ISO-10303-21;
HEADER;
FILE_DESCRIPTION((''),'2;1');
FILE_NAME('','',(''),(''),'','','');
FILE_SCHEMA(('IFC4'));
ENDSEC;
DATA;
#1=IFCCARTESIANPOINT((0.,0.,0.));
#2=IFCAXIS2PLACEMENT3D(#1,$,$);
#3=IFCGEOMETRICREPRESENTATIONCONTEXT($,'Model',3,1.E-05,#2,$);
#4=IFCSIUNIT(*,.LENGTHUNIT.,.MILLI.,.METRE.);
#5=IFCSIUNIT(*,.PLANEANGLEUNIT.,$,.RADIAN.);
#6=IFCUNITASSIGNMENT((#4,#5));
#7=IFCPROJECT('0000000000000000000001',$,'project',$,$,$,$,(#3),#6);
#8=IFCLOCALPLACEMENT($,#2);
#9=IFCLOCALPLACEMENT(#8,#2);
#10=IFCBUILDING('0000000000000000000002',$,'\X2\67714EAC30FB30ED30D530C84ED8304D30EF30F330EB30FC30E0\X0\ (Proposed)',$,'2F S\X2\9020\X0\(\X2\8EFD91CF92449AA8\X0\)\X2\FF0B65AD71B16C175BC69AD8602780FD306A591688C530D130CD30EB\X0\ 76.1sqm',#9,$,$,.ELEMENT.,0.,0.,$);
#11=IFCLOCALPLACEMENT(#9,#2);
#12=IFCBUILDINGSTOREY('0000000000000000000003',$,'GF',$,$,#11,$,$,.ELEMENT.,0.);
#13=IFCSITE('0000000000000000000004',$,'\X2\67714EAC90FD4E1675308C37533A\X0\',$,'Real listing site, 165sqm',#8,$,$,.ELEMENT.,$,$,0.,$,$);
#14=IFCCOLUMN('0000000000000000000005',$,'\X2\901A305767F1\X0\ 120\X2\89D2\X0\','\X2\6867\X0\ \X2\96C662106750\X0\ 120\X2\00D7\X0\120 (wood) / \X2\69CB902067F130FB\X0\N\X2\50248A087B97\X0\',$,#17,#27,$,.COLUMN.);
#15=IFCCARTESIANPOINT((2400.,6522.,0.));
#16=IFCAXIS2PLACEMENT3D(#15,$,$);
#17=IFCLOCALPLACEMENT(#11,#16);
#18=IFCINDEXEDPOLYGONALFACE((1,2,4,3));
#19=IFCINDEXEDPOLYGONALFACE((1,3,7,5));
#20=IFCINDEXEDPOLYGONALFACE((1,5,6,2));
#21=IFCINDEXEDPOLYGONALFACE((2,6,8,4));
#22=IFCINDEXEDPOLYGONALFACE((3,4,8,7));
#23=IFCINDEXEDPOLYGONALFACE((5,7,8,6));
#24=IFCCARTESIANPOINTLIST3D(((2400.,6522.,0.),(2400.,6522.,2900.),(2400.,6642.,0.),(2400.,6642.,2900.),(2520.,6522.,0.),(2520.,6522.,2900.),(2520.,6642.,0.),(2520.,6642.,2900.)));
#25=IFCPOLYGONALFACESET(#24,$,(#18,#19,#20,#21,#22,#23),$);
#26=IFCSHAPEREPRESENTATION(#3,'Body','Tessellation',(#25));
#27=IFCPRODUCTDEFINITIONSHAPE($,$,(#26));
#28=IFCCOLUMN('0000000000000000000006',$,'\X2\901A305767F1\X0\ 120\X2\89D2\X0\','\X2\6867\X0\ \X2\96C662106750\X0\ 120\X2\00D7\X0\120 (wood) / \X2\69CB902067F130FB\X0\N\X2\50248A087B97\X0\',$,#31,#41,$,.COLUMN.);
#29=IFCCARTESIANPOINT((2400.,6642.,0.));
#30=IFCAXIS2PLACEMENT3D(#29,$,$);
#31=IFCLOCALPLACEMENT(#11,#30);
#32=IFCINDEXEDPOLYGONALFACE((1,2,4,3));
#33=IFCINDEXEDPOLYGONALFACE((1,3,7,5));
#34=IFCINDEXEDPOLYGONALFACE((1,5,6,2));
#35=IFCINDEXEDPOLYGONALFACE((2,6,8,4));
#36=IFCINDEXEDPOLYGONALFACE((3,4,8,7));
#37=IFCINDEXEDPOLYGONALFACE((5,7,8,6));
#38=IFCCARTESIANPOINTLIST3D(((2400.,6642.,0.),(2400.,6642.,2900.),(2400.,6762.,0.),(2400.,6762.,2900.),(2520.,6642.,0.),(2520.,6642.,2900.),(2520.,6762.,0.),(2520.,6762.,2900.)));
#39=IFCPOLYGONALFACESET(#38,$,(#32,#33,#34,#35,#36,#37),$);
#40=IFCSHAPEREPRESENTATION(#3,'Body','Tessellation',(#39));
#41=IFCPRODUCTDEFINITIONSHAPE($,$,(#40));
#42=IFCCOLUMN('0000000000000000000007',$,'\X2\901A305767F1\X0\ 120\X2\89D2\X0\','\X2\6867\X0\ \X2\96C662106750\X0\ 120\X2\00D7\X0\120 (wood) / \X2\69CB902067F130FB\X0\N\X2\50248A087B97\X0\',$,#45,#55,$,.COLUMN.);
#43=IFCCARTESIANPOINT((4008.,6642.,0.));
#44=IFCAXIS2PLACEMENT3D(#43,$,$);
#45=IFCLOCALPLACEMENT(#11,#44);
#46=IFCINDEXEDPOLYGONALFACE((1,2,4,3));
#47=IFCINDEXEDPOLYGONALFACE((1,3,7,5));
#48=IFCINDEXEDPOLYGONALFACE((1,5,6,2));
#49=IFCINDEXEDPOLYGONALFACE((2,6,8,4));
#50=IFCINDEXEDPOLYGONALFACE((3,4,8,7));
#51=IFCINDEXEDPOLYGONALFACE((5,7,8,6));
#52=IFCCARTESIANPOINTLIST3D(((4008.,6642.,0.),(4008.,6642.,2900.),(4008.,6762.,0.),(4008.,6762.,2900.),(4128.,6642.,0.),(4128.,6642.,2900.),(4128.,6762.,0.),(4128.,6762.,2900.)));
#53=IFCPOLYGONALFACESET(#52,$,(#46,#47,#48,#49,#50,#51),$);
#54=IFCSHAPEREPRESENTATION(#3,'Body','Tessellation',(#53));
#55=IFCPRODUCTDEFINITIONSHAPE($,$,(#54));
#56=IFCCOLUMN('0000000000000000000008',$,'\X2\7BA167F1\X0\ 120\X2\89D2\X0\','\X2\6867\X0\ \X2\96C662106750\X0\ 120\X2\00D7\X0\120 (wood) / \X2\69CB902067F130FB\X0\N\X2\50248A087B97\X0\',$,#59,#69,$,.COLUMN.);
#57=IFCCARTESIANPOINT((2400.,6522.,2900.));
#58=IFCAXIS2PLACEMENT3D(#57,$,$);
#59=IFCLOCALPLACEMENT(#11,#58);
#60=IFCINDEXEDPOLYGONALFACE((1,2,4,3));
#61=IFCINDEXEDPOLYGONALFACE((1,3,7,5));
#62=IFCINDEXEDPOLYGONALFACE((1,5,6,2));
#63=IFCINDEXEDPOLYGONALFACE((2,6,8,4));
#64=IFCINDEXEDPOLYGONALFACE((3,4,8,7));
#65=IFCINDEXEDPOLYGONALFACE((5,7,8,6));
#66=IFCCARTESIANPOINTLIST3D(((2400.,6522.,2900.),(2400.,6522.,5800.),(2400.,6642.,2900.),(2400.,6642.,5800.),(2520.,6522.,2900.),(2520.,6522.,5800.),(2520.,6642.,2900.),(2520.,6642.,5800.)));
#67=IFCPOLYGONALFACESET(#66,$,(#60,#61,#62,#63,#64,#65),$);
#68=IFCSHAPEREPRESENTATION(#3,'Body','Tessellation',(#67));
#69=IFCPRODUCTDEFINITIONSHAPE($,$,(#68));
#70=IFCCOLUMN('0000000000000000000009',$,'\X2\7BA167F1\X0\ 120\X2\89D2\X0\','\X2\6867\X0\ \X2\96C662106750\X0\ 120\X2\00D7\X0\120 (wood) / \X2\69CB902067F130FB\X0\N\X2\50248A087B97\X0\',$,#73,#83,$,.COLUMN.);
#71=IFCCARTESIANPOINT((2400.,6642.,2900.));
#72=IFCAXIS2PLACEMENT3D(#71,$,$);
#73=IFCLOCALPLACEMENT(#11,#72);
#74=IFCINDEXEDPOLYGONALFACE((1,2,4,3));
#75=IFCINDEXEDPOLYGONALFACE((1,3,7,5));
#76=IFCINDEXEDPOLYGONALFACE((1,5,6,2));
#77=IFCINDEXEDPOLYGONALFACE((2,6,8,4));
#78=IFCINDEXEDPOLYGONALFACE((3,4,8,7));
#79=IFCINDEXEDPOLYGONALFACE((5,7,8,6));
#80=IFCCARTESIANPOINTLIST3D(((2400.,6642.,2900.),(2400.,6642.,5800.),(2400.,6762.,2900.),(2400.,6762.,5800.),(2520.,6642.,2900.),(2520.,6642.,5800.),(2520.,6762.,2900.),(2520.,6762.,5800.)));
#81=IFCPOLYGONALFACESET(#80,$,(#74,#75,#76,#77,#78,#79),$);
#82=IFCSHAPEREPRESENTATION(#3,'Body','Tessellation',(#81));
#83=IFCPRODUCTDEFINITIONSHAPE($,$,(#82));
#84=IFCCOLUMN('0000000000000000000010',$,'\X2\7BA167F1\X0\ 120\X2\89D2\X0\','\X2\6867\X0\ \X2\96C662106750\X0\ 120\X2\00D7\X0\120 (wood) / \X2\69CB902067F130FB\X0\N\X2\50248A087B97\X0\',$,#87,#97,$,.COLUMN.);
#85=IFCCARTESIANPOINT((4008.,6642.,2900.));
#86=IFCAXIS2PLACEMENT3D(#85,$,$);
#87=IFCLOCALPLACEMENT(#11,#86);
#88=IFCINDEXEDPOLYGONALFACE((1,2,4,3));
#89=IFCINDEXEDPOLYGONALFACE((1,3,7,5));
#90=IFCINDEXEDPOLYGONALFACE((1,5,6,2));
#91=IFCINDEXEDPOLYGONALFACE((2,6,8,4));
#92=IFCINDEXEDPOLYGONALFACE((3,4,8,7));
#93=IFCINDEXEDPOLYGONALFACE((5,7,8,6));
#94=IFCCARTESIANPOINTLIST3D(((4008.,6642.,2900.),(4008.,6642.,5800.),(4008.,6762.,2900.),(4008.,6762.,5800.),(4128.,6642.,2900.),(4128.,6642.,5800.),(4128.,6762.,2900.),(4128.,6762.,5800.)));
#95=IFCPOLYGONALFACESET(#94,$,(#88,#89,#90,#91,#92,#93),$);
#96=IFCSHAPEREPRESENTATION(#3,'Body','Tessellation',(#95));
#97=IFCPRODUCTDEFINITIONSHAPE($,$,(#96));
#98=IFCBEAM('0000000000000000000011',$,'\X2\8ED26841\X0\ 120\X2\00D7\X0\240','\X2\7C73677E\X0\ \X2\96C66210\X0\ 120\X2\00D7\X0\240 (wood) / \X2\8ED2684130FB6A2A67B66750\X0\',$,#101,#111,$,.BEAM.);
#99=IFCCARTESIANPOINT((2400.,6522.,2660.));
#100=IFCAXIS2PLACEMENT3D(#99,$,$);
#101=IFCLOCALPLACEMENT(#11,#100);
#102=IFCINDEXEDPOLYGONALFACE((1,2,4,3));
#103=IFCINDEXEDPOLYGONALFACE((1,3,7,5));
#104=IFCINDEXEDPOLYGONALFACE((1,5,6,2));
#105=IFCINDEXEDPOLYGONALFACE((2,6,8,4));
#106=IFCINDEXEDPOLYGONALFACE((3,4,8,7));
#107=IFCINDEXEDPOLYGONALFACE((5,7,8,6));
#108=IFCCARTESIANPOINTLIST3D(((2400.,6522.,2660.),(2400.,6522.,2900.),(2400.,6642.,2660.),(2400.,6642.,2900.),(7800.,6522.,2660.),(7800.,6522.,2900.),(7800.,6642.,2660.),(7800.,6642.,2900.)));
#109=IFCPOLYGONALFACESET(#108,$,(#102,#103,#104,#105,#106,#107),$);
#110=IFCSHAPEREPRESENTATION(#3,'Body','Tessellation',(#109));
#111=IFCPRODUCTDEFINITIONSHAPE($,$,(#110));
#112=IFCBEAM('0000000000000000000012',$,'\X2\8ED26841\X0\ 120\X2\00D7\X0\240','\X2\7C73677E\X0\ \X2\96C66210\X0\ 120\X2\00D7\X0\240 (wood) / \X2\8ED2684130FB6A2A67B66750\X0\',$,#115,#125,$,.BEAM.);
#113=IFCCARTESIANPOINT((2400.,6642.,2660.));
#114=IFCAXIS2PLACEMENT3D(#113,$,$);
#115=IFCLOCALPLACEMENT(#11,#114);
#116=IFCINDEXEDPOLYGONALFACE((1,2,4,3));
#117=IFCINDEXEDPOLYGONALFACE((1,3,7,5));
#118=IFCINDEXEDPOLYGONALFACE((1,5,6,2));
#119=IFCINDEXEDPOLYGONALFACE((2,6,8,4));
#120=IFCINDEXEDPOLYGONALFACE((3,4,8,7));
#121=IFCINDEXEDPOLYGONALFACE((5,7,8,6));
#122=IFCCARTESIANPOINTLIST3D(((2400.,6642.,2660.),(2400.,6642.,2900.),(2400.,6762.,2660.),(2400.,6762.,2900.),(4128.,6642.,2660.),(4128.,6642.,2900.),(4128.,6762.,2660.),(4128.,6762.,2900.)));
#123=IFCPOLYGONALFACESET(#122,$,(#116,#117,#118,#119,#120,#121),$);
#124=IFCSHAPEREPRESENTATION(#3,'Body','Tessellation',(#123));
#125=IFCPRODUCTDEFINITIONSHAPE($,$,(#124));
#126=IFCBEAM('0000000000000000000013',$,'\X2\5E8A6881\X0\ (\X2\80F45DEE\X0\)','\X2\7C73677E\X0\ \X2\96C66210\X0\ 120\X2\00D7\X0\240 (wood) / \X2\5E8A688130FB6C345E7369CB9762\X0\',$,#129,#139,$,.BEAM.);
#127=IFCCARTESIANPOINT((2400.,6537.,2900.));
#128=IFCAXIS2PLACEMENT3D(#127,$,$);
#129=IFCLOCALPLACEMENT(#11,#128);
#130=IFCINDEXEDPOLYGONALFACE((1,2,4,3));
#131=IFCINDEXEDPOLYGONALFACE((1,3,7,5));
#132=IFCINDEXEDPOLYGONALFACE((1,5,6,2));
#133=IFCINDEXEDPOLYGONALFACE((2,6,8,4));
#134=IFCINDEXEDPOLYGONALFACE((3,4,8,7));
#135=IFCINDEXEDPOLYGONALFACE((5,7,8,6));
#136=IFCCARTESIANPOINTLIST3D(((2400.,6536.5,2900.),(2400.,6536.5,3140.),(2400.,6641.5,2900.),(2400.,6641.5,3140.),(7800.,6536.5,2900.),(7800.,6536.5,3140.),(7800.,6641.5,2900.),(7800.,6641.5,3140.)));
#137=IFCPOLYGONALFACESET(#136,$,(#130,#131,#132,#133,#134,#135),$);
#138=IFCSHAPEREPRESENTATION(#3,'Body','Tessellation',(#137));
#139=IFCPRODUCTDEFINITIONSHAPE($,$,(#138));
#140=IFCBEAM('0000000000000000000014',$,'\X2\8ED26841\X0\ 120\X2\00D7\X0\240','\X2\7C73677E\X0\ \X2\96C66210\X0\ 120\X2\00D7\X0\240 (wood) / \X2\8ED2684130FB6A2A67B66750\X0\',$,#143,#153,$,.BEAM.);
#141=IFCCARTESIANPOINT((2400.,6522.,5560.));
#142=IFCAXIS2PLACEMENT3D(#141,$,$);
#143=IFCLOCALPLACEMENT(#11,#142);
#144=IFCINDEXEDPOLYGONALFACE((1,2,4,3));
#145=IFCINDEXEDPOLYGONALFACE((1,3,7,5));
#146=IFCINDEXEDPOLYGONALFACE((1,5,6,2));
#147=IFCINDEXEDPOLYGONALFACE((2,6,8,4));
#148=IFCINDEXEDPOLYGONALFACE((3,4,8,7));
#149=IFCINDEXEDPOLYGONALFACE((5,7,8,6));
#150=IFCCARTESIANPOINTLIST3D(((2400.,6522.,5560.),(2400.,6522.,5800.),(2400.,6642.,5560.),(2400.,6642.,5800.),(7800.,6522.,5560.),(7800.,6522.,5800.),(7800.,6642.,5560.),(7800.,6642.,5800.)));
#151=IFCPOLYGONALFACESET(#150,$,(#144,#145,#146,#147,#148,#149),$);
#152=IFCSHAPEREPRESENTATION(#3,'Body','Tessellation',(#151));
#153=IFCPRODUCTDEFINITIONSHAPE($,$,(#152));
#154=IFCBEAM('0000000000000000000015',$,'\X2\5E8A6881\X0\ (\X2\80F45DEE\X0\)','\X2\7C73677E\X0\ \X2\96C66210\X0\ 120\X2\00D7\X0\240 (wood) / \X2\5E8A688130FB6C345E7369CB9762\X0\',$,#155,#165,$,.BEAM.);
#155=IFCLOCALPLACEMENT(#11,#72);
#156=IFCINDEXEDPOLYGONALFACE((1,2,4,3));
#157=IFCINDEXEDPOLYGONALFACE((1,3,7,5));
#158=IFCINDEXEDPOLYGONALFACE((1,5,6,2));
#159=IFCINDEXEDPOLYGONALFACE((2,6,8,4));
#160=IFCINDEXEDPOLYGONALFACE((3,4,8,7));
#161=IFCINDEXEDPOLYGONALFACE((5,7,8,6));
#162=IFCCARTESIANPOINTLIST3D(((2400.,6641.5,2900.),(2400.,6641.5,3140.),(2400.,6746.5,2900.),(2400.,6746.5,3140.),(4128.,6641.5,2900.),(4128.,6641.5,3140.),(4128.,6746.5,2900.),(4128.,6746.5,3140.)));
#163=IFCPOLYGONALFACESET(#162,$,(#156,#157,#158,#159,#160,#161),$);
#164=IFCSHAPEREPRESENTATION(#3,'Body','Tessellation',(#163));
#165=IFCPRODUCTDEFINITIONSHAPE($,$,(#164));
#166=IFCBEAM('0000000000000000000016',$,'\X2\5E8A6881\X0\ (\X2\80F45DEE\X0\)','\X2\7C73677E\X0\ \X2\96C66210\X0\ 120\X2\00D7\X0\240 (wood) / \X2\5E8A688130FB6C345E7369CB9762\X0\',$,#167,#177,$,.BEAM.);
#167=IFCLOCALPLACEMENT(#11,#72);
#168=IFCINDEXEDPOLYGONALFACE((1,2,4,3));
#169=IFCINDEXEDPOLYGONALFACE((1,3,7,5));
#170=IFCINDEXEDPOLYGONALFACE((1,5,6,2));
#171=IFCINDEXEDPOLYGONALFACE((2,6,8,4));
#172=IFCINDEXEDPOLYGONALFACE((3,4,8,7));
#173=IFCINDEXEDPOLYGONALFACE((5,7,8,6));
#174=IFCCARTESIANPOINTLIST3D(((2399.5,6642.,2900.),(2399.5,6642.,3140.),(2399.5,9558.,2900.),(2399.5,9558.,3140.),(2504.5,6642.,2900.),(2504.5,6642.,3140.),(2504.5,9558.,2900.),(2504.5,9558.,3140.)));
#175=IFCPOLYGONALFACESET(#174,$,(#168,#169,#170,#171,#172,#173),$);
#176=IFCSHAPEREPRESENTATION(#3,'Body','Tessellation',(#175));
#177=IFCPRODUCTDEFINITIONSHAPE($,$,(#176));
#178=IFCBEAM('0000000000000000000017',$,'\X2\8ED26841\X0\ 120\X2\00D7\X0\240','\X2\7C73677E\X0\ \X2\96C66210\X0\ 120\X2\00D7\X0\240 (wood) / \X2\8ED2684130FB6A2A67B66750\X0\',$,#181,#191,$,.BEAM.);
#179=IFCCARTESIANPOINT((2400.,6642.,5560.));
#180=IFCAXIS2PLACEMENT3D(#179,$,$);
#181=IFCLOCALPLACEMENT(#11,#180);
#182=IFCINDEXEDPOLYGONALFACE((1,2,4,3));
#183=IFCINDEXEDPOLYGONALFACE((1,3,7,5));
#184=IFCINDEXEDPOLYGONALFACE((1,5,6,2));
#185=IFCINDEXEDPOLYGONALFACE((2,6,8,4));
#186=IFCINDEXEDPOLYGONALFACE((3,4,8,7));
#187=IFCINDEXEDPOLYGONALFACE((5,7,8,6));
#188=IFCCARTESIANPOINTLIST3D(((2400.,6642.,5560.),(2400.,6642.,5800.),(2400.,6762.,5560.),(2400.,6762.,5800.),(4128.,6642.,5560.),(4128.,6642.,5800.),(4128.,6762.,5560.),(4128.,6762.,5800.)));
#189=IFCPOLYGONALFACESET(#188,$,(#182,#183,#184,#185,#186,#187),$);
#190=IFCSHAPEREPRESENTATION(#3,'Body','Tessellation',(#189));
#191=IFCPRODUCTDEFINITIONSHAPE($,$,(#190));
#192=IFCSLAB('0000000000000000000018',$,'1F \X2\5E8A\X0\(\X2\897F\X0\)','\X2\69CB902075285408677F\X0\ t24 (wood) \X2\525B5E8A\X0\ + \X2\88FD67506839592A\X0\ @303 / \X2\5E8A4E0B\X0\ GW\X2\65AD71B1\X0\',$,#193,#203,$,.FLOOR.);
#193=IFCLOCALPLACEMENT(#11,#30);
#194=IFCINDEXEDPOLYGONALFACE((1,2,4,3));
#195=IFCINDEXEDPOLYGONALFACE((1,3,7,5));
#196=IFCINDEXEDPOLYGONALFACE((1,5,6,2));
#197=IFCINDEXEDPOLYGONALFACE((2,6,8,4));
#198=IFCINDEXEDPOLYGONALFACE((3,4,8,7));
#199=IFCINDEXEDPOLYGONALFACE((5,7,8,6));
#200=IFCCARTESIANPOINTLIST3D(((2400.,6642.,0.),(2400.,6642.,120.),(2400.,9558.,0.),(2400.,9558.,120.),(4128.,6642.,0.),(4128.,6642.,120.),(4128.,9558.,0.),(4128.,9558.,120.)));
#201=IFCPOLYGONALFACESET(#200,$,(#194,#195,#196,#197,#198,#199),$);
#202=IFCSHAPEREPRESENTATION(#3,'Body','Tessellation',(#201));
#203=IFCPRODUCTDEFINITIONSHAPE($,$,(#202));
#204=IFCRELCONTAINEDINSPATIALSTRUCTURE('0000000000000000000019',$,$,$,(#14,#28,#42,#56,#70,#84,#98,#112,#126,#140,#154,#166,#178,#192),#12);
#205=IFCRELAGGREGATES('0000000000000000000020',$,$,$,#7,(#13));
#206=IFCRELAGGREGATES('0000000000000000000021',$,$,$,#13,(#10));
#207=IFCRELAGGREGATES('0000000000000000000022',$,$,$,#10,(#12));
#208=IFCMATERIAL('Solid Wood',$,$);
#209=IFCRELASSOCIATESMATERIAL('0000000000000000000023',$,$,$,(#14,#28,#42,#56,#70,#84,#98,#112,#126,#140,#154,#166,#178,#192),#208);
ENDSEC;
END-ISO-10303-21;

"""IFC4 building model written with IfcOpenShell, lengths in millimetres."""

from ifc_helpers import new_model, si_unit, frame, frame_2d, origin, place, context, project, spatial, rectangle, extrude, material, element, save


model = new_model("IFC4")

# Units and contexts
model_context = context("Model", 3, precision=1e-05, world=origin())
ifc_project = project(units=[si_unit("LENGTHUNIT", "METRE", prefix="MILLI"), si_unit("PLANEANGLEUNIT", "RADIAN")], contexts=[model_context])

# Site, building, storey
site_placement = place(None, origin())
site = spatial("IfcSite", under=ifc_project, at=site_placement, Name="東京都世田谷区", ObjectType="Real listing site, 165sqm", CompositionType="ELEMENT", RefElevation=0.0)
building_placement = place(site_placement, origin())
building = spatial("IfcBuilding", under=site, at=building_placement, Name="東京・ロフト付きワンルーム (Proposed)", ObjectType="2F S造(軽量鉄骨)＋断熱気密高性能な外装パネル 76.1sqm", CompositionType="ELEMENT", ElevationOfRefHeight=0.0, ElevationOfTerrain=0.0)
storey_placement = place(building_placement, origin())
storey = spatial("IfcBuildingStorey", under=building, at=storey_placement, Name="GF", CompositionType="ELEMENT", Elevation=0.0)

# Columns
ifc_material_1 = material(Name="Solid Wood")
column_1_placement = place(storey_placement, frame((2400.0, 6522.0, 0.0)))
element("IfcColumn", 1, at=column_1_placement, inside=storey, material=ifc_material_1, Name="通し柱 120角", Description="桧 集成材 120×120 (wood) / 構造柱・N値計算", PredefinedType="COLUMN", context=model_context, shape_type="SweptSolid", body=[
    extrude(rectangle(XDim=120.0, YDim=120.0, at=frame_2d((60.0, 60.0))), frame((2400.0, 6522.0, 0.0)), (0.0, 0.0, 1.0), 2900.0),
])
column_2_placement = place(storey_placement, frame((2400.0, 6642.0, 0.0)))
element("IfcColumn", 2, at=column_2_placement, inside=storey, material=ifc_material_1, Name="通し柱 120角", Description="桧 集成材 120×120 (wood) / 構造柱・N値計算", PredefinedType="COLUMN", context=model_context, shape_type="SweptSolid", body=[
    extrude(rectangle(XDim=120.0, YDim=120.0, at=frame_2d((60.0, 60.0))), frame((2400.0, 6642.0, 0.0)), (0.0, 0.0, 1.0), 2900.0),
])
column_3_placement = place(storey_placement, frame((4008.0, 6642.0, 0.0)))
element("IfcColumn", 3, at=column_3_placement, inside=storey, material=ifc_material_1, Name="通し柱 120角", Description="桧 集成材 120×120 (wood) / 構造柱・N値計算", PredefinedType="COLUMN", context=model_context, shape_type="SweptSolid", body=[
    extrude(rectangle(XDim=120.0, YDim=120.0, at=frame_2d((60.0, 60.0))), frame((4008.0, 6642.0, 0.0)), (0.0, 0.0, 1.0), 2900.0),
])
column_4_placement = place(storey_placement, frame((2400.0, 6522.0, 2900.0)))
element("IfcColumn", 4, at=column_4_placement, inside=storey, material=ifc_material_1, Name="管柱 120角", Description="桧 集成材 120×120 (wood) / 構造柱・N値計算", PredefinedType="COLUMN", context=model_context, shape_type="SweptSolid", body=[
    extrude(rectangle(XDim=120.0, YDim=120.0, at=frame_2d((60.0, 60.0))), frame((2400.0, 6522.0, 2900.0)), (0.0, 0.0, 1.0), 2900.0),
])
column_5_placement = place(storey_placement, frame((2400.0, 6642.0, 2900.0)))
element("IfcColumn", 5, at=column_5_placement, inside=storey, material=ifc_material_1, Name="管柱 120角", Description="桧 集成材 120×120 (wood) / 構造柱・N値計算", PredefinedType="COLUMN", context=model_context, shape_type="SweptSolid", body=[
    extrude(rectangle(XDim=120.0, YDim=120.0, at=frame_2d((60.0, 60.0))), frame((2400.0, 6642.0, 2900.0)), (0.0, 0.0, 1.0), 2900.0),
])
column_6_placement = place(storey_placement, frame((4008.0, 6642.0, 2900.0)))
element("IfcColumn", 6, at=column_6_placement, inside=storey, material=ifc_material_1, Name="管柱 120角", Description="桧 集成材 120×120 (wood) / 構造柱・N値計算", PredefinedType="COLUMN", context=model_context, shape_type="SweptSolid", body=[
    extrude(rectangle(XDim=120.0, YDim=120.0, at=frame_2d((60.0, 60.0))), frame((4008.0, 6642.0, 2900.0)), (0.0, 0.0, 1.0), 2900.0),
])

# Beams
beam_1_placement = place(storey_placement, frame((2400.0, 6522.0, 2660.0)))
element("IfcBeam", 7, at=beam_1_placement, inside=storey, material=ifc_material_1, Name="軒桁 120×240", Description="米松 集成 120×240 (wood) / 軒桁・横架材", PredefinedType="BEAM", context=model_context, shape_type="SweptSolid", body=[
    extrude(rectangle(XDim=5400.0, YDim=120.0, at=frame_2d((2700.0, 60.0))), frame((2400.0, 6522.0, 2660.0)), (0.0, 0.0, 1.0), 240.0),
])
beam_2_placement = place(storey_placement, frame((2400.0, 6642.0, 2660.0)))
element("IfcBeam", 8, at=beam_2_placement, inside=storey, material=ifc_material_1, Name="軒桁 120×240", Description="米松 集成 120×240 (wood) / 軒桁・横架材", PredefinedType="BEAM", context=model_context, shape_type="SweptSolid", body=[
    extrude(rectangle(XDim=1728.0, YDim=120.0, at=frame_2d((864.0, 60.0))), frame((2400.0, 6642.0, 2660.0)), (0.0, 0.0, 1.0), 240.0),
])
beam_3_placement = place(storey_placement, frame((2400.0, 6537.0, 2900.0)))
element("IfcBeam", 9, at=beam_3_placement, inside=storey, material=ifc_material_1, Name="床梁 (胴差)", Description="米松 集成 120×240 (wood) / 床梁・水平構面", PredefinedType="BEAM", context=model_context, shape_type="SweptSolid", body=[
    extrude(rectangle(XDim=5400.0, YDim=105.0, at=frame_2d((2700.0, 52.0))), frame((2400.0, 6537.0, 2900.0)), (0.0, 0.0, 1.0), 240.0),
])
beam_4_placement = place(storey_placement, frame((2400.0, 6522.0, 5560.0)))
element("IfcBeam", 10, at=beam_4_placement, inside=storey, material=ifc_material_1, Name="軒桁 120×240", Description="米松 集成 120×240 (wood) / 軒桁・横架材", PredefinedType="BEAM", context=model_context, shape_type="SweptSolid", body=[
    extrude(rectangle(XDim=5400.0, YDim=120.0, at=frame_2d((2700.0, 60.0))), frame((2400.0, 6522.0, 5560.0)), (0.0, 0.0, 1.0), 240.0),
])
beam_5_placement = place(storey_placement, frame((2400.0, 6642.0, 2900.0)))
element("IfcBeam", 11, at=beam_5_placement, inside=storey, material=ifc_material_1, Name="床梁 (胴差)", Description="米松 集成 120×240 (wood) / 床梁・水平構面", PredefinedType="BEAM", context=model_context, shape_type="SweptSolid", body=[
    extrude(rectangle(XDim=1728.0, YDim=105.0, at=frame_2d((864.0, 52.0))), frame((2400.0, 6642.0, 2900.0)), (0.0, 0.0, 1.0), 240.0),
])
beam_6_placement = place(storey_placement, frame((2400.0, 6642.0, 2900.0)))
element("IfcBeam", 12, at=beam_6_placement, inside=storey, material=ifc_material_1, Name="床梁 (胴差)", Description="米松 集成 120×240 (wood) / 床梁・水平構面", PredefinedType="BEAM", context=model_context, shape_type="SweptSolid", body=[
    extrude(rectangle(XDim=105.0, YDim=2916.0, at=frame_2d((52.0, 1458.0))), frame((2400.0, 6642.0, 2900.0)), (0.0, 0.0, 1.0), 240.0),
])
beam_7_placement = place(storey_placement, frame((2400.0, 6642.0, 5560.0)))
element("IfcBeam", 13, at=beam_7_placement, inside=storey, material=ifc_material_1, Name="軒桁 120×240", Description="米松 集成 120×240 (wood) / 軒桁・横架材", PredefinedType="BEAM", context=model_context, shape_type="SweptSolid", body=[
    extrude(rectangle(XDim=1728.0, YDim=120.0, at=frame_2d((864.0, 60.0))), frame((2400.0, 6642.0, 5560.0)), (0.0, 0.0, 1.0), 240.0),
])

# Slab
slab_1_placement = place(storey_placement, frame((2400.0, 6642.0, 0.0)))
element("IfcSlab", 14, at=slab_1_placement, inside=storey, material=ifc_material_1, Name="1F 床(西)", Description="構造用合板 t24 (wood) 剛床 + 製材根太 @303 / 床下 GW断熱", PredefinedType="FLOOR", context=model_context, shape_type="SweptSolid", body=[
    extrude(rectangle(XDim=1728.0, YDim=2916.0, at=frame_2d((864.0, 1458.0))), frame((2400.0, 6642.0, 0.0)), (0.0, 0.0, 1.0), 120.0),
])

save(model, "model.ifc")
